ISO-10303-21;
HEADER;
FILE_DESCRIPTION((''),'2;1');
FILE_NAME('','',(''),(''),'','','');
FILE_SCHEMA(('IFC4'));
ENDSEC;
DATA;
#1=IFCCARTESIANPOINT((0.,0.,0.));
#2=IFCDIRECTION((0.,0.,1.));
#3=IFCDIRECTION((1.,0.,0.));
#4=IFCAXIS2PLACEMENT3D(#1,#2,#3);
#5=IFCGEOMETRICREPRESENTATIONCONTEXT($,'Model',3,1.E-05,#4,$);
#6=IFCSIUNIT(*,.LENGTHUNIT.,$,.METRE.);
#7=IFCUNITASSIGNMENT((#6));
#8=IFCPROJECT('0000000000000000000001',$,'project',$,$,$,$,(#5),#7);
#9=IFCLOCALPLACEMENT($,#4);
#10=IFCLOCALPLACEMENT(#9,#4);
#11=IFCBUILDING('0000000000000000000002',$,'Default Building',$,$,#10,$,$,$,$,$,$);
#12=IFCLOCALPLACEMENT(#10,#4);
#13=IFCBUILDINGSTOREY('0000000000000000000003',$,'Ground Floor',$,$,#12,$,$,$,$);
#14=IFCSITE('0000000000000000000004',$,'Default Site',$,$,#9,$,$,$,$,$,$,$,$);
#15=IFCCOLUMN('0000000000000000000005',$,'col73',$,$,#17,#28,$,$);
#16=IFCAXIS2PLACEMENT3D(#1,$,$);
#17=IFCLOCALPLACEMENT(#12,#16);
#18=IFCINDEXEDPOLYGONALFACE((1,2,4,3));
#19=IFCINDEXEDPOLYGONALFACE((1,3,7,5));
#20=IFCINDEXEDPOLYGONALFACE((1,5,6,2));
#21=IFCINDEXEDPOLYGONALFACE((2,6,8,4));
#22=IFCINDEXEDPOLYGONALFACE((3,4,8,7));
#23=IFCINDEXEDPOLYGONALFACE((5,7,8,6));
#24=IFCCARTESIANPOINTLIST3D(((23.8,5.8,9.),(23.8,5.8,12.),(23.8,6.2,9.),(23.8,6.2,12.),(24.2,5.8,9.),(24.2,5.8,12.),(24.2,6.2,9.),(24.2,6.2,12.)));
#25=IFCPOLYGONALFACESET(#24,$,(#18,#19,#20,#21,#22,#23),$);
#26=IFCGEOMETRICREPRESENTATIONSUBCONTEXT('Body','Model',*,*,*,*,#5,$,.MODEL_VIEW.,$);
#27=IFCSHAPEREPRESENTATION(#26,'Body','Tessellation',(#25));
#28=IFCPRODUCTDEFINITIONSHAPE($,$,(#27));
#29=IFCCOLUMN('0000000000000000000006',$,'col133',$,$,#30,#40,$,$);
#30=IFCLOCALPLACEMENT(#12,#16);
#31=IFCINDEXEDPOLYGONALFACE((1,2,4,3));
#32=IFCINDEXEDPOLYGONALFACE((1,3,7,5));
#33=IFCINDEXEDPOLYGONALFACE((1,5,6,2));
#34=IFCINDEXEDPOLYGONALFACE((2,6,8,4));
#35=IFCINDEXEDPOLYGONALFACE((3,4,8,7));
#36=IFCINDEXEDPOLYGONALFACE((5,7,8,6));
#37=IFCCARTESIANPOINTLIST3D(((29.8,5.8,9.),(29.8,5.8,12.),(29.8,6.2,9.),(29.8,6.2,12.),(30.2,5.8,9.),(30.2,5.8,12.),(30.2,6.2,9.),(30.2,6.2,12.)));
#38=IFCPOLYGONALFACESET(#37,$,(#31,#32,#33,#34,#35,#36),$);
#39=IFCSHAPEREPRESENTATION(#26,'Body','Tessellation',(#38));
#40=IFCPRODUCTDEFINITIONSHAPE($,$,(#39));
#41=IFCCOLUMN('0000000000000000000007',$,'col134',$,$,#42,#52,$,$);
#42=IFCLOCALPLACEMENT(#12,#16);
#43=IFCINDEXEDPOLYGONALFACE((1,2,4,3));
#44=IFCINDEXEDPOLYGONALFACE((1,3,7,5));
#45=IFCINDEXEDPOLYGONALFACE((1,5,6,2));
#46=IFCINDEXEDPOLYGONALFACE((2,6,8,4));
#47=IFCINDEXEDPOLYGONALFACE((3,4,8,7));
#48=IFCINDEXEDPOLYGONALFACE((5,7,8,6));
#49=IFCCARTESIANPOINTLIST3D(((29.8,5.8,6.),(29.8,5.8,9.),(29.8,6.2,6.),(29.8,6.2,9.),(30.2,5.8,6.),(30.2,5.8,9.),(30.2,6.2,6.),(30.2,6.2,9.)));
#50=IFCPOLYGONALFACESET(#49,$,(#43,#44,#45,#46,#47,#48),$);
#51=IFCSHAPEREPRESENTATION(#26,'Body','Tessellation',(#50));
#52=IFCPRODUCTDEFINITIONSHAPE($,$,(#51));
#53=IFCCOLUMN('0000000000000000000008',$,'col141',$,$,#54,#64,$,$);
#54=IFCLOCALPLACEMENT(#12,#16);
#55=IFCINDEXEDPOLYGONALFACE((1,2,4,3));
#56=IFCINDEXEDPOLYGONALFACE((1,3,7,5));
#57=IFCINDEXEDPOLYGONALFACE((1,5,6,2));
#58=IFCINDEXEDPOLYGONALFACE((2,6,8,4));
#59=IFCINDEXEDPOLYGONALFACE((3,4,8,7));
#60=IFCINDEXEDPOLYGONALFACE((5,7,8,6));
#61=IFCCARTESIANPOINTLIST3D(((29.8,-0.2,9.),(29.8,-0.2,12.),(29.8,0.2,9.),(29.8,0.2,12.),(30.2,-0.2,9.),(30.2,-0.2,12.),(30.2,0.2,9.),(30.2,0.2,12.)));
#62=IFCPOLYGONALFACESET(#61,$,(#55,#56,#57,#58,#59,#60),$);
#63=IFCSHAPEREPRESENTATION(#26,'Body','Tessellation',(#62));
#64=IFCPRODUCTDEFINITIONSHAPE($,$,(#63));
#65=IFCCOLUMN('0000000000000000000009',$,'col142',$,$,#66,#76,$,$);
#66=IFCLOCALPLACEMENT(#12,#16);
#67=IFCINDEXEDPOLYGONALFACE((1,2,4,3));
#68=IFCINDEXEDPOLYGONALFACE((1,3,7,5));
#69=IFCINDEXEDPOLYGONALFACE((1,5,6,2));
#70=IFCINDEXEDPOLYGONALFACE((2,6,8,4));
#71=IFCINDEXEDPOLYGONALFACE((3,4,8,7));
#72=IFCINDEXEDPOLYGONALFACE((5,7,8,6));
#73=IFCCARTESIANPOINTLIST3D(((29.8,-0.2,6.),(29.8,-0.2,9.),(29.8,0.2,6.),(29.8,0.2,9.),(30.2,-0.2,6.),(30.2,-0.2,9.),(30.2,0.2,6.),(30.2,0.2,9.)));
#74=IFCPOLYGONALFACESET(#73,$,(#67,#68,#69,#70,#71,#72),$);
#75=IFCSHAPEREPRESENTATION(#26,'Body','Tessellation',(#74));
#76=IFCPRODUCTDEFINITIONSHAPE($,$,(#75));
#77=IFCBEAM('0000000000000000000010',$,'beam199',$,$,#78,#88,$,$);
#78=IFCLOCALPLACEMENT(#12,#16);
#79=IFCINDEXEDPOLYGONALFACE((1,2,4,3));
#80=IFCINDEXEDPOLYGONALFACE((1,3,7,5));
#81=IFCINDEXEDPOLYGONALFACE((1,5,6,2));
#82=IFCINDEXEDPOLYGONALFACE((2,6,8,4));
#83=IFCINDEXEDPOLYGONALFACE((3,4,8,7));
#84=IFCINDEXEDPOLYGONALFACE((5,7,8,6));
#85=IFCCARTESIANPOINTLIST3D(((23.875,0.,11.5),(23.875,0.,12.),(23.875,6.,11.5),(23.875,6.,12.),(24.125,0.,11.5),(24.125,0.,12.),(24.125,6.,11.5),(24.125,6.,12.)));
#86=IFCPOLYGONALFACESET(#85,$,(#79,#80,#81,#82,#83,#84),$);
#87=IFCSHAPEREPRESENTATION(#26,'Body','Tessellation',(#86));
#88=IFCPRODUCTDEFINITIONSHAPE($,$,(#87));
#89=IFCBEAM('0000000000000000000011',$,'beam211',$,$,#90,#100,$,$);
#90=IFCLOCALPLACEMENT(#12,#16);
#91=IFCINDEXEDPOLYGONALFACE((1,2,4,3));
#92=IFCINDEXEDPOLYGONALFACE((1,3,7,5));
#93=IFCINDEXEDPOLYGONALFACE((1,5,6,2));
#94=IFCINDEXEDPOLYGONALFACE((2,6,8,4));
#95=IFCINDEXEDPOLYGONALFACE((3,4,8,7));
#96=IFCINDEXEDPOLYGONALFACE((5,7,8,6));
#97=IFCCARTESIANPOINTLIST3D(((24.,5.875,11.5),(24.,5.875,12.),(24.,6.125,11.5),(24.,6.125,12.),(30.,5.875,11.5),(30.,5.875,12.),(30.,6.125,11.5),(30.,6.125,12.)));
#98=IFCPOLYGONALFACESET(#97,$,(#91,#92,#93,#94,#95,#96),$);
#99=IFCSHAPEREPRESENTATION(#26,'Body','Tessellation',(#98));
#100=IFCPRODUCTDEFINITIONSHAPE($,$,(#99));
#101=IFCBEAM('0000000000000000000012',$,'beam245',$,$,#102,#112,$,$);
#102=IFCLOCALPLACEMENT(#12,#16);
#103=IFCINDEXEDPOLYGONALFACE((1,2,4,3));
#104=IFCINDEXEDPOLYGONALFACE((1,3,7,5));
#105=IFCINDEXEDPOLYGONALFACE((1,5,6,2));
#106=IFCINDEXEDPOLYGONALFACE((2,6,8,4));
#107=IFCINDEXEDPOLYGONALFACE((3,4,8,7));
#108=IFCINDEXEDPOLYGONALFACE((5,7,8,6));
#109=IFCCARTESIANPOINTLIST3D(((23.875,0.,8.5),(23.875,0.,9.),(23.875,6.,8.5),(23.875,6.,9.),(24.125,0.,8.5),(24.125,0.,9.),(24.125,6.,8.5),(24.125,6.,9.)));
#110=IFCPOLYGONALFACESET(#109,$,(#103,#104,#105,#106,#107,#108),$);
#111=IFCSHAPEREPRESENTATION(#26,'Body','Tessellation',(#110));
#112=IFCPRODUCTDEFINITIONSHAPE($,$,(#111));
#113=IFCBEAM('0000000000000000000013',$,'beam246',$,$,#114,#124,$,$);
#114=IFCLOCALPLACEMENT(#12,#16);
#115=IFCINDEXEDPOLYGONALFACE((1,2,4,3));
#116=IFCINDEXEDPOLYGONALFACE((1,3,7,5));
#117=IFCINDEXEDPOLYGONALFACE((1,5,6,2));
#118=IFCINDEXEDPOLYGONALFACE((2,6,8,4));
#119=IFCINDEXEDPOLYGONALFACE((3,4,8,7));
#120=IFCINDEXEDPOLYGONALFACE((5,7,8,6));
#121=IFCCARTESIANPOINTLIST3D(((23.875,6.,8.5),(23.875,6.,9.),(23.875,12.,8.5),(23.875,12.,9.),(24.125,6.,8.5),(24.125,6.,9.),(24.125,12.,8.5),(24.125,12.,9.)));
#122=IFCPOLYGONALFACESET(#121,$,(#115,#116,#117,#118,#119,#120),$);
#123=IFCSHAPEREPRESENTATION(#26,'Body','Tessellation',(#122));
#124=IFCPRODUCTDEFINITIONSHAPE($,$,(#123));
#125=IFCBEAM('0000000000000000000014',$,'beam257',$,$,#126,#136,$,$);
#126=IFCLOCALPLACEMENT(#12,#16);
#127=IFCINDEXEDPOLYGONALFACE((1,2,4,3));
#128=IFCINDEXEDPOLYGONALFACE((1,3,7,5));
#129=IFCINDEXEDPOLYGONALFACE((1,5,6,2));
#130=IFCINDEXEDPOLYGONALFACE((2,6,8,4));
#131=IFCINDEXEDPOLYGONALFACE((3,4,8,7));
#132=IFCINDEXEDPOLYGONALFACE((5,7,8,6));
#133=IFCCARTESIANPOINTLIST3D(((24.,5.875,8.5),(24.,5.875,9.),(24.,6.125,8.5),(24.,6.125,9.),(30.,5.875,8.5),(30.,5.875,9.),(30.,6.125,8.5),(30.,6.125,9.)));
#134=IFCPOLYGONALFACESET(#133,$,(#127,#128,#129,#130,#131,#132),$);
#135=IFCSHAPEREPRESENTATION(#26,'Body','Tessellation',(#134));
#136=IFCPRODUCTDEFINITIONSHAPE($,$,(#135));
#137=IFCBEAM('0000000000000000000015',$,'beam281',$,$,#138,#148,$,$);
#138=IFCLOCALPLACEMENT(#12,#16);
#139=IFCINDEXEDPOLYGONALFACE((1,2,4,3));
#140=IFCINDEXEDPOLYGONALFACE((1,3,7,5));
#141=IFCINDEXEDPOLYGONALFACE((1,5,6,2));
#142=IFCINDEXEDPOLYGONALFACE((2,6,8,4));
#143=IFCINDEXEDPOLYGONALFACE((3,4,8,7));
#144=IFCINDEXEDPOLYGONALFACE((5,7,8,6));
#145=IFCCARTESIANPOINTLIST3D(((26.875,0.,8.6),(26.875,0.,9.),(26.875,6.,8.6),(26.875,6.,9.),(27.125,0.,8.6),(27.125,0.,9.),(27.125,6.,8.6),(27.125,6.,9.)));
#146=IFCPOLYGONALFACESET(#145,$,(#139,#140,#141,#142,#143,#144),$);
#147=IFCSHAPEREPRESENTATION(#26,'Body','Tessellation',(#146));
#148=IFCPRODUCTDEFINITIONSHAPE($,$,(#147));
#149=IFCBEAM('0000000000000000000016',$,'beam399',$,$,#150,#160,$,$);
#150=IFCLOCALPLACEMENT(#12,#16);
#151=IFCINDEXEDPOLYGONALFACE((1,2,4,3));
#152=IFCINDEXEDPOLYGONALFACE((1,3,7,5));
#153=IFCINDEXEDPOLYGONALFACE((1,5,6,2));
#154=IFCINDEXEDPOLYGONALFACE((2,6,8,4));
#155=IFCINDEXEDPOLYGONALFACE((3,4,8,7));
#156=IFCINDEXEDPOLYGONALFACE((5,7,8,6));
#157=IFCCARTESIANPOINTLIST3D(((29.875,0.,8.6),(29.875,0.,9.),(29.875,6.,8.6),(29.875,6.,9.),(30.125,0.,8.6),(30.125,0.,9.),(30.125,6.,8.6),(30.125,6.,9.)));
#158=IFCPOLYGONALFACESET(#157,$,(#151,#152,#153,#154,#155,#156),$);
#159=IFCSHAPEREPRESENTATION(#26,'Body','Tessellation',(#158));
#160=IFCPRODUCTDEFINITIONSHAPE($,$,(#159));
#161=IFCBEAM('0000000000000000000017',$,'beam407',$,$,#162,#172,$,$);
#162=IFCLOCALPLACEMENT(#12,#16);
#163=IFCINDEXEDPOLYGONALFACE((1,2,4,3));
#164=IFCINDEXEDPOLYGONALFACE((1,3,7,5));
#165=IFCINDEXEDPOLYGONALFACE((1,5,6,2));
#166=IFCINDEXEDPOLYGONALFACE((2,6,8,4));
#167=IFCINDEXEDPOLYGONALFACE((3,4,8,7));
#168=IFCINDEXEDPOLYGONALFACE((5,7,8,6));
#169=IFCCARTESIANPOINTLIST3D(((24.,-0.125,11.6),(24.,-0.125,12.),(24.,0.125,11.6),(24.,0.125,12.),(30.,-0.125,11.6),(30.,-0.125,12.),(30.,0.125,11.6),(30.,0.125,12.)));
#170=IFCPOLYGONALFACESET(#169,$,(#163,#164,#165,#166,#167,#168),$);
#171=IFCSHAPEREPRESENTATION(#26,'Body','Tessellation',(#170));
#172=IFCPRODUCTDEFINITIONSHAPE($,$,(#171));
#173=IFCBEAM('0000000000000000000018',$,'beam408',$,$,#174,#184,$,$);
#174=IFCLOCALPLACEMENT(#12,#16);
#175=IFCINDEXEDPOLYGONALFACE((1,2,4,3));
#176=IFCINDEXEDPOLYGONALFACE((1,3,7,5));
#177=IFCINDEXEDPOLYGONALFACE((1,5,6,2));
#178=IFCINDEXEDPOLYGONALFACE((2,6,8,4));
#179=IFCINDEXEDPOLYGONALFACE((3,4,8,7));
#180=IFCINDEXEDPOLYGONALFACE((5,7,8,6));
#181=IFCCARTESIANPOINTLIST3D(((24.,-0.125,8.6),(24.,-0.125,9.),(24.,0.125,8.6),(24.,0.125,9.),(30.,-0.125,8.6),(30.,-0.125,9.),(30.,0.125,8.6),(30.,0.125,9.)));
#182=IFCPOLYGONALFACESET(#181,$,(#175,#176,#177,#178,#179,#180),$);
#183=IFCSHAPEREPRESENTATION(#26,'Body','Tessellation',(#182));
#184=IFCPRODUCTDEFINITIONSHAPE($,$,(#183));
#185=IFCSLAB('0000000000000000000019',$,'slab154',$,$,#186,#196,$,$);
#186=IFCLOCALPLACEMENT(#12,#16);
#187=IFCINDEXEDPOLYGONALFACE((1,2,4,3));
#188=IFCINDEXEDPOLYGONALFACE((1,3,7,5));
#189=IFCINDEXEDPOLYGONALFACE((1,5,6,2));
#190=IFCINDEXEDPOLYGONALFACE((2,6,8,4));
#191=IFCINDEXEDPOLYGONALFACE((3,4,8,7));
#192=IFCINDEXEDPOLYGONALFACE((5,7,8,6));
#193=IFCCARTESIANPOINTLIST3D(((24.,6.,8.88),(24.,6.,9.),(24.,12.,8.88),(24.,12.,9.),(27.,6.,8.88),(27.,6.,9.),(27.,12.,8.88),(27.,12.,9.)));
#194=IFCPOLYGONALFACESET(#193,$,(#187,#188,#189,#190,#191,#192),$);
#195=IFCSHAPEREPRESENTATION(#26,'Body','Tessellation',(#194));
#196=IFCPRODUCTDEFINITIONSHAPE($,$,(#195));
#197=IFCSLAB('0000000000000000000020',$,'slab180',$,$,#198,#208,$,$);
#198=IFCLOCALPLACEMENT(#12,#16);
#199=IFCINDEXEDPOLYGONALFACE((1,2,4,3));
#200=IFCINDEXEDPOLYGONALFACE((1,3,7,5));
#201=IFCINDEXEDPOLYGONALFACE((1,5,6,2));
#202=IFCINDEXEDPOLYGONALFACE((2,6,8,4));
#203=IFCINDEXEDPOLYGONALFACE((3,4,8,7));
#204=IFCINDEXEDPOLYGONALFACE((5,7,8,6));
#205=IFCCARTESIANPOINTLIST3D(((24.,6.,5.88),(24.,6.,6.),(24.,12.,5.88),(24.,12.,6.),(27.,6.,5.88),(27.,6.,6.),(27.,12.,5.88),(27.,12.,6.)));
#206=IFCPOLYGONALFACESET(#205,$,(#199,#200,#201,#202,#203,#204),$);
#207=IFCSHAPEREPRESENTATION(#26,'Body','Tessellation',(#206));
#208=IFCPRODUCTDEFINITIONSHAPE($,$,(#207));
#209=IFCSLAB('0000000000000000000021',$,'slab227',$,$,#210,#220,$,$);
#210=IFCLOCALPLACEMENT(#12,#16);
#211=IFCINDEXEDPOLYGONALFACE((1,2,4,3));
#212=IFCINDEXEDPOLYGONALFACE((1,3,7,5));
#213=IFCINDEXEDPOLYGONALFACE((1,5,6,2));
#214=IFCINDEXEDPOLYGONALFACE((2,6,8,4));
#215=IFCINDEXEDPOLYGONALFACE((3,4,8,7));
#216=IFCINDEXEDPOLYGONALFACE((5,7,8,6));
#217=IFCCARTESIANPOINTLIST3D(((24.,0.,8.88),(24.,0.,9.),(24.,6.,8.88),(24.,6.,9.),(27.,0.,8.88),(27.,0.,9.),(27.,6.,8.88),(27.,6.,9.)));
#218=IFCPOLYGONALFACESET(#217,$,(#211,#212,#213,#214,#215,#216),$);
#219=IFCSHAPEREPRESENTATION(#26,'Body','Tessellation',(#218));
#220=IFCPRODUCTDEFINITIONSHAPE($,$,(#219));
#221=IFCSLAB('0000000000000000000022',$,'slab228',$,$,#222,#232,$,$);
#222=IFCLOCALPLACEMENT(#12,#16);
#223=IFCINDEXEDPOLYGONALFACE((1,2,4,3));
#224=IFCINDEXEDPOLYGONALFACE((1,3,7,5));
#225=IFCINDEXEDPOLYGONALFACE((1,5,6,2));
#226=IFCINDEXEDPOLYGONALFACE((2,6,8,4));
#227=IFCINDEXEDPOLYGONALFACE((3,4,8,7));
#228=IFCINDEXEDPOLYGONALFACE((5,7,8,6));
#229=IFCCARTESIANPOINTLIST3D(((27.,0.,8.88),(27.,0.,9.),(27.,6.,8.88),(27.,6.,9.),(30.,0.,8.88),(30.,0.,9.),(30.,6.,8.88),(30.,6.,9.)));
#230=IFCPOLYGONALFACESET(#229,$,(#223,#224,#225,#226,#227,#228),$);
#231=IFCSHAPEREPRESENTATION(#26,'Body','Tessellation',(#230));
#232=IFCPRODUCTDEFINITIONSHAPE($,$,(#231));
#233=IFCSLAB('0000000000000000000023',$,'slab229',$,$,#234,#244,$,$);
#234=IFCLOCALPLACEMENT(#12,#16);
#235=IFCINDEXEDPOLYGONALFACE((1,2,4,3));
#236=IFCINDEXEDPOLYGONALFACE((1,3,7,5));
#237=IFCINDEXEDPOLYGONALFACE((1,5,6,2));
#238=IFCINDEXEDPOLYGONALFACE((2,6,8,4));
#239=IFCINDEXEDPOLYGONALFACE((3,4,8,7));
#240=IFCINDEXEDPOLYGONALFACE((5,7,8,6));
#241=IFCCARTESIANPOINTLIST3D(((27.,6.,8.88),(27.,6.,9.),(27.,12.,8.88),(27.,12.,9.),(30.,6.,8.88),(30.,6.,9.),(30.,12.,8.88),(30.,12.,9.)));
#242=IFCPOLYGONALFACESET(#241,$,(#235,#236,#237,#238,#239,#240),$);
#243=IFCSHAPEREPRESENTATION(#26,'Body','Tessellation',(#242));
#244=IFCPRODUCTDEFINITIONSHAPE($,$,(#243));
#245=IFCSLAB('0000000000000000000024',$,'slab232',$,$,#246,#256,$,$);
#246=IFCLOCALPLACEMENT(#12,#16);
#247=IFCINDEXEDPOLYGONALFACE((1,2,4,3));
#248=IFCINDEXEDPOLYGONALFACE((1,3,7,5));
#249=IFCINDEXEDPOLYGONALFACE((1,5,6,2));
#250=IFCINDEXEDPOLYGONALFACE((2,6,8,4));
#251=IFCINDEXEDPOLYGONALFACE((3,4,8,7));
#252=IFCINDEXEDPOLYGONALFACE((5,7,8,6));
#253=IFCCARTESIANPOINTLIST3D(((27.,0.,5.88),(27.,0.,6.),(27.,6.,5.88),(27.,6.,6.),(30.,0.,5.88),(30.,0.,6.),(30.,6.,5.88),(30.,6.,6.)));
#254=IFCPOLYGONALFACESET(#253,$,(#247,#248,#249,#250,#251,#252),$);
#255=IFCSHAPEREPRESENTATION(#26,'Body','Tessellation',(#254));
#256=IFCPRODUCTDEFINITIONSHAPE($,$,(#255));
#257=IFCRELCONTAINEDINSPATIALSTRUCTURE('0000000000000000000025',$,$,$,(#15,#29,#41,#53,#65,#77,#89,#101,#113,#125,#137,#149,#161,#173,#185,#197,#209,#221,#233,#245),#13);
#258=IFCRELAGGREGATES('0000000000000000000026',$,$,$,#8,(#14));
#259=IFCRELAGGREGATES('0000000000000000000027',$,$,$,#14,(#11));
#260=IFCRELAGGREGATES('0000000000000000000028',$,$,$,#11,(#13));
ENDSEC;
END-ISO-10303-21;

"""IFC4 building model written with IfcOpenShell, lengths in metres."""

from ifc_helpers import new_model, si_unit, frame, origin_with_axes, place, context, subcontext, project, spatial, indexed_curve, outline, extrude, element, save


model = new_model("IFC4")

# Units and contexts
model_context = context("Model", 3, precision=1e-05, world=origin_with_axes())
body_context = subcontext(model_context, "Body", "Model", "MODEL_VIEW")
ifc_project = project(units=[si_unit("LENGTHUNIT", "METRE")], contexts=[model_context])

# Site, building, storey
site_placement = place(None, origin_with_axes())
site = spatial("IfcSite", under=ifc_project, at=site_placement, Name="Default Site")
building_placement = place(site_placement, origin_with_axes())
building = spatial("IfcBuilding", under=site, at=building_placement, Name="Default Building")
storey_placement = place(building_placement, origin_with_axes())
storey = spatial("IfcBuildingStorey", under=building, at=storey_placement, Name="Ground Floor")

# Columns
for number, where, z_axis, x_axis, name in (
    (1, (23.8, 5.8, 9.0), (0.0, 0.0, 1.0), (1.0, 0.0, 0.0), "col73"),
    (2, (29.8, 5.8, 9.0), (0.0, 0.0, 1.0), (1.0, 0.0, 0.0), "col133"),
    (3, (29.8, 5.8, 6.0), (0.0, 0.0, 1.0), (1.0, 0.0, 0.0), "col134"),
    (4, (29.8, -0.2, 9.0), (0.0, 0.0, 1.0), (1.0, 0.0, 0.0), "col141"),
    (5, (29.8, -0.2, 6.0), (0.0, 0.0, 1.0), (1.0, 0.0, 0.0), "col142"),
):
    element("IfcColumn", number, at=place(storey_placement, frame(where, z_axis=z_axis, x_axis=x_axis)), inside=storey, Name=name, context=body_context, shape_type="SweptSolid", body=[
        extrude(outline(indexed_curve([(0.0, 0.0), (0.0, 0.4), (0.4, 0.4), (0.4, 0.0), (0.0, 0.0)], self_intersect=False)), origin_with_axes(), (0.0, 0.0, 1.0), 3.0),
    ])

# Beams
for number, where, z_axis, x_axis, name in (
    (6, (24.125, 0.0, 11.5), (0.0, 0.0, 1.0), (0.0, 1.0, 0.0), "beam199"),
    (7, (24.0, 5.875, 11.5), (0.0, 0.0, 1.0), (1.0, 0.0, 0.0), "beam211"),
    (8, (24.125, 0.0, 8.5), (0.0, 0.0, 1.0), (0.0, 1.0, 0.0), "beam245"),
    (9, (24.125, 6.0, 8.5), (0.0, 0.0, 1.0), (0.0, 1.0, 0.0), "beam246"),
    (10, (24.0, 5.875, 8.5), (0.0, 0.0, 1.0), (1.0, 0.0, 0.0), "beam257"),
):
    element("IfcBeam", number, at=place(storey_placement, frame(where, z_axis=z_axis, x_axis=x_axis)), inside=storey, Name=name, context=body_context, shape_type="SweptSolid", body=[
        extrude(outline(indexed_curve([(0.0, 0.0), (0.0, 0.25), (6.0, 0.25), (6.0, 0.0), (0.0, 0.0)], self_intersect=False)), origin_with_axes(), (0.0, 0.0, 1.0), 0.5),
    ])
for number, where, z_axis, x_axis, name in (
    (11, (26.875, 6.0, 8.6), (0.0, 0.0, 1.0), (0.0, -1.0, 0.0), "beam281"),
    (12, (29.875, 6.0, 8.6), (0.0, 0.0, 1.0), (0.0, -1.0, 0.0), "beam399"),
    (13, (24.0, -0.125, 11.6), (0.0, 0.0, 1.0), (1.0, 0.0, 0.0), "beam407"),
    (14, (24.0, -0.125, 8.6), (0.0, 0.0, 1.0), (1.0, 0.0, 0.0), "beam408"),
):
    element("IfcBeam", number, at=place(storey_placement, frame(where, z_axis=z_axis, x_axis=x_axis)), inside=storey, Name=name, context=body_context, shape_type="SweptSolid", body=[
        extrude(outline(indexed_curve([(0.0, 0.0), (0.0, 0.25), (6.0, 0.25), (6.0, 0.0), (0.0, 0.0)], self_intersect=False)), origin_with_axes(), (0.0, 0.0, 1.0), 0.4),
    ])

# Slabs
for number, where, z_axis, x_axis, name in (
    (15, (24.0, 6.0, 8.88), (0.0, 0.0, 1.0), (1.0, 0.0, 0.0), "slab154"),
    (16, (24.0, 6.0, 5.88), (0.0, 0.0, 1.0), (1.0, 0.0, 0.0), "slab180"),
    (17, (24.0, 0.0, 8.88), (0.0, 0.0, 1.0), (1.0, 0.0, 0.0), "slab227"),
    (18, (27.0, 0.0, 8.88), (0.0, 0.0, 1.0), (1.0, 0.0, 0.0), "slab228"),
    (19, (27.0, 6.0, 8.88), (0.0, 0.0, 1.0), (1.0, 0.0, 0.0), "slab229"),
    (20, (27.0, 0.0, 5.88), (0.0, 0.0, 1.0), (1.0, 0.0, 0.0), "slab232"),
):
    element("IfcSlab", number, at=place(storey_placement, frame(where, z_axis=z_axis, x_axis=x_axis)), inside=storey, Name=name, context=body_context, shape_type="SweptSolid", body=[
        extrude(outline(indexed_curve([(0.0, 0.0), (0.0, 6.0), (3.0, 6.0), (3.0, 0.0), (0.0, 0.0)], self_intersect=False)), origin_with_axes(), (0.0, 0.0, 1.0), 0.12),
    ])

save(model, "model.ifc")
